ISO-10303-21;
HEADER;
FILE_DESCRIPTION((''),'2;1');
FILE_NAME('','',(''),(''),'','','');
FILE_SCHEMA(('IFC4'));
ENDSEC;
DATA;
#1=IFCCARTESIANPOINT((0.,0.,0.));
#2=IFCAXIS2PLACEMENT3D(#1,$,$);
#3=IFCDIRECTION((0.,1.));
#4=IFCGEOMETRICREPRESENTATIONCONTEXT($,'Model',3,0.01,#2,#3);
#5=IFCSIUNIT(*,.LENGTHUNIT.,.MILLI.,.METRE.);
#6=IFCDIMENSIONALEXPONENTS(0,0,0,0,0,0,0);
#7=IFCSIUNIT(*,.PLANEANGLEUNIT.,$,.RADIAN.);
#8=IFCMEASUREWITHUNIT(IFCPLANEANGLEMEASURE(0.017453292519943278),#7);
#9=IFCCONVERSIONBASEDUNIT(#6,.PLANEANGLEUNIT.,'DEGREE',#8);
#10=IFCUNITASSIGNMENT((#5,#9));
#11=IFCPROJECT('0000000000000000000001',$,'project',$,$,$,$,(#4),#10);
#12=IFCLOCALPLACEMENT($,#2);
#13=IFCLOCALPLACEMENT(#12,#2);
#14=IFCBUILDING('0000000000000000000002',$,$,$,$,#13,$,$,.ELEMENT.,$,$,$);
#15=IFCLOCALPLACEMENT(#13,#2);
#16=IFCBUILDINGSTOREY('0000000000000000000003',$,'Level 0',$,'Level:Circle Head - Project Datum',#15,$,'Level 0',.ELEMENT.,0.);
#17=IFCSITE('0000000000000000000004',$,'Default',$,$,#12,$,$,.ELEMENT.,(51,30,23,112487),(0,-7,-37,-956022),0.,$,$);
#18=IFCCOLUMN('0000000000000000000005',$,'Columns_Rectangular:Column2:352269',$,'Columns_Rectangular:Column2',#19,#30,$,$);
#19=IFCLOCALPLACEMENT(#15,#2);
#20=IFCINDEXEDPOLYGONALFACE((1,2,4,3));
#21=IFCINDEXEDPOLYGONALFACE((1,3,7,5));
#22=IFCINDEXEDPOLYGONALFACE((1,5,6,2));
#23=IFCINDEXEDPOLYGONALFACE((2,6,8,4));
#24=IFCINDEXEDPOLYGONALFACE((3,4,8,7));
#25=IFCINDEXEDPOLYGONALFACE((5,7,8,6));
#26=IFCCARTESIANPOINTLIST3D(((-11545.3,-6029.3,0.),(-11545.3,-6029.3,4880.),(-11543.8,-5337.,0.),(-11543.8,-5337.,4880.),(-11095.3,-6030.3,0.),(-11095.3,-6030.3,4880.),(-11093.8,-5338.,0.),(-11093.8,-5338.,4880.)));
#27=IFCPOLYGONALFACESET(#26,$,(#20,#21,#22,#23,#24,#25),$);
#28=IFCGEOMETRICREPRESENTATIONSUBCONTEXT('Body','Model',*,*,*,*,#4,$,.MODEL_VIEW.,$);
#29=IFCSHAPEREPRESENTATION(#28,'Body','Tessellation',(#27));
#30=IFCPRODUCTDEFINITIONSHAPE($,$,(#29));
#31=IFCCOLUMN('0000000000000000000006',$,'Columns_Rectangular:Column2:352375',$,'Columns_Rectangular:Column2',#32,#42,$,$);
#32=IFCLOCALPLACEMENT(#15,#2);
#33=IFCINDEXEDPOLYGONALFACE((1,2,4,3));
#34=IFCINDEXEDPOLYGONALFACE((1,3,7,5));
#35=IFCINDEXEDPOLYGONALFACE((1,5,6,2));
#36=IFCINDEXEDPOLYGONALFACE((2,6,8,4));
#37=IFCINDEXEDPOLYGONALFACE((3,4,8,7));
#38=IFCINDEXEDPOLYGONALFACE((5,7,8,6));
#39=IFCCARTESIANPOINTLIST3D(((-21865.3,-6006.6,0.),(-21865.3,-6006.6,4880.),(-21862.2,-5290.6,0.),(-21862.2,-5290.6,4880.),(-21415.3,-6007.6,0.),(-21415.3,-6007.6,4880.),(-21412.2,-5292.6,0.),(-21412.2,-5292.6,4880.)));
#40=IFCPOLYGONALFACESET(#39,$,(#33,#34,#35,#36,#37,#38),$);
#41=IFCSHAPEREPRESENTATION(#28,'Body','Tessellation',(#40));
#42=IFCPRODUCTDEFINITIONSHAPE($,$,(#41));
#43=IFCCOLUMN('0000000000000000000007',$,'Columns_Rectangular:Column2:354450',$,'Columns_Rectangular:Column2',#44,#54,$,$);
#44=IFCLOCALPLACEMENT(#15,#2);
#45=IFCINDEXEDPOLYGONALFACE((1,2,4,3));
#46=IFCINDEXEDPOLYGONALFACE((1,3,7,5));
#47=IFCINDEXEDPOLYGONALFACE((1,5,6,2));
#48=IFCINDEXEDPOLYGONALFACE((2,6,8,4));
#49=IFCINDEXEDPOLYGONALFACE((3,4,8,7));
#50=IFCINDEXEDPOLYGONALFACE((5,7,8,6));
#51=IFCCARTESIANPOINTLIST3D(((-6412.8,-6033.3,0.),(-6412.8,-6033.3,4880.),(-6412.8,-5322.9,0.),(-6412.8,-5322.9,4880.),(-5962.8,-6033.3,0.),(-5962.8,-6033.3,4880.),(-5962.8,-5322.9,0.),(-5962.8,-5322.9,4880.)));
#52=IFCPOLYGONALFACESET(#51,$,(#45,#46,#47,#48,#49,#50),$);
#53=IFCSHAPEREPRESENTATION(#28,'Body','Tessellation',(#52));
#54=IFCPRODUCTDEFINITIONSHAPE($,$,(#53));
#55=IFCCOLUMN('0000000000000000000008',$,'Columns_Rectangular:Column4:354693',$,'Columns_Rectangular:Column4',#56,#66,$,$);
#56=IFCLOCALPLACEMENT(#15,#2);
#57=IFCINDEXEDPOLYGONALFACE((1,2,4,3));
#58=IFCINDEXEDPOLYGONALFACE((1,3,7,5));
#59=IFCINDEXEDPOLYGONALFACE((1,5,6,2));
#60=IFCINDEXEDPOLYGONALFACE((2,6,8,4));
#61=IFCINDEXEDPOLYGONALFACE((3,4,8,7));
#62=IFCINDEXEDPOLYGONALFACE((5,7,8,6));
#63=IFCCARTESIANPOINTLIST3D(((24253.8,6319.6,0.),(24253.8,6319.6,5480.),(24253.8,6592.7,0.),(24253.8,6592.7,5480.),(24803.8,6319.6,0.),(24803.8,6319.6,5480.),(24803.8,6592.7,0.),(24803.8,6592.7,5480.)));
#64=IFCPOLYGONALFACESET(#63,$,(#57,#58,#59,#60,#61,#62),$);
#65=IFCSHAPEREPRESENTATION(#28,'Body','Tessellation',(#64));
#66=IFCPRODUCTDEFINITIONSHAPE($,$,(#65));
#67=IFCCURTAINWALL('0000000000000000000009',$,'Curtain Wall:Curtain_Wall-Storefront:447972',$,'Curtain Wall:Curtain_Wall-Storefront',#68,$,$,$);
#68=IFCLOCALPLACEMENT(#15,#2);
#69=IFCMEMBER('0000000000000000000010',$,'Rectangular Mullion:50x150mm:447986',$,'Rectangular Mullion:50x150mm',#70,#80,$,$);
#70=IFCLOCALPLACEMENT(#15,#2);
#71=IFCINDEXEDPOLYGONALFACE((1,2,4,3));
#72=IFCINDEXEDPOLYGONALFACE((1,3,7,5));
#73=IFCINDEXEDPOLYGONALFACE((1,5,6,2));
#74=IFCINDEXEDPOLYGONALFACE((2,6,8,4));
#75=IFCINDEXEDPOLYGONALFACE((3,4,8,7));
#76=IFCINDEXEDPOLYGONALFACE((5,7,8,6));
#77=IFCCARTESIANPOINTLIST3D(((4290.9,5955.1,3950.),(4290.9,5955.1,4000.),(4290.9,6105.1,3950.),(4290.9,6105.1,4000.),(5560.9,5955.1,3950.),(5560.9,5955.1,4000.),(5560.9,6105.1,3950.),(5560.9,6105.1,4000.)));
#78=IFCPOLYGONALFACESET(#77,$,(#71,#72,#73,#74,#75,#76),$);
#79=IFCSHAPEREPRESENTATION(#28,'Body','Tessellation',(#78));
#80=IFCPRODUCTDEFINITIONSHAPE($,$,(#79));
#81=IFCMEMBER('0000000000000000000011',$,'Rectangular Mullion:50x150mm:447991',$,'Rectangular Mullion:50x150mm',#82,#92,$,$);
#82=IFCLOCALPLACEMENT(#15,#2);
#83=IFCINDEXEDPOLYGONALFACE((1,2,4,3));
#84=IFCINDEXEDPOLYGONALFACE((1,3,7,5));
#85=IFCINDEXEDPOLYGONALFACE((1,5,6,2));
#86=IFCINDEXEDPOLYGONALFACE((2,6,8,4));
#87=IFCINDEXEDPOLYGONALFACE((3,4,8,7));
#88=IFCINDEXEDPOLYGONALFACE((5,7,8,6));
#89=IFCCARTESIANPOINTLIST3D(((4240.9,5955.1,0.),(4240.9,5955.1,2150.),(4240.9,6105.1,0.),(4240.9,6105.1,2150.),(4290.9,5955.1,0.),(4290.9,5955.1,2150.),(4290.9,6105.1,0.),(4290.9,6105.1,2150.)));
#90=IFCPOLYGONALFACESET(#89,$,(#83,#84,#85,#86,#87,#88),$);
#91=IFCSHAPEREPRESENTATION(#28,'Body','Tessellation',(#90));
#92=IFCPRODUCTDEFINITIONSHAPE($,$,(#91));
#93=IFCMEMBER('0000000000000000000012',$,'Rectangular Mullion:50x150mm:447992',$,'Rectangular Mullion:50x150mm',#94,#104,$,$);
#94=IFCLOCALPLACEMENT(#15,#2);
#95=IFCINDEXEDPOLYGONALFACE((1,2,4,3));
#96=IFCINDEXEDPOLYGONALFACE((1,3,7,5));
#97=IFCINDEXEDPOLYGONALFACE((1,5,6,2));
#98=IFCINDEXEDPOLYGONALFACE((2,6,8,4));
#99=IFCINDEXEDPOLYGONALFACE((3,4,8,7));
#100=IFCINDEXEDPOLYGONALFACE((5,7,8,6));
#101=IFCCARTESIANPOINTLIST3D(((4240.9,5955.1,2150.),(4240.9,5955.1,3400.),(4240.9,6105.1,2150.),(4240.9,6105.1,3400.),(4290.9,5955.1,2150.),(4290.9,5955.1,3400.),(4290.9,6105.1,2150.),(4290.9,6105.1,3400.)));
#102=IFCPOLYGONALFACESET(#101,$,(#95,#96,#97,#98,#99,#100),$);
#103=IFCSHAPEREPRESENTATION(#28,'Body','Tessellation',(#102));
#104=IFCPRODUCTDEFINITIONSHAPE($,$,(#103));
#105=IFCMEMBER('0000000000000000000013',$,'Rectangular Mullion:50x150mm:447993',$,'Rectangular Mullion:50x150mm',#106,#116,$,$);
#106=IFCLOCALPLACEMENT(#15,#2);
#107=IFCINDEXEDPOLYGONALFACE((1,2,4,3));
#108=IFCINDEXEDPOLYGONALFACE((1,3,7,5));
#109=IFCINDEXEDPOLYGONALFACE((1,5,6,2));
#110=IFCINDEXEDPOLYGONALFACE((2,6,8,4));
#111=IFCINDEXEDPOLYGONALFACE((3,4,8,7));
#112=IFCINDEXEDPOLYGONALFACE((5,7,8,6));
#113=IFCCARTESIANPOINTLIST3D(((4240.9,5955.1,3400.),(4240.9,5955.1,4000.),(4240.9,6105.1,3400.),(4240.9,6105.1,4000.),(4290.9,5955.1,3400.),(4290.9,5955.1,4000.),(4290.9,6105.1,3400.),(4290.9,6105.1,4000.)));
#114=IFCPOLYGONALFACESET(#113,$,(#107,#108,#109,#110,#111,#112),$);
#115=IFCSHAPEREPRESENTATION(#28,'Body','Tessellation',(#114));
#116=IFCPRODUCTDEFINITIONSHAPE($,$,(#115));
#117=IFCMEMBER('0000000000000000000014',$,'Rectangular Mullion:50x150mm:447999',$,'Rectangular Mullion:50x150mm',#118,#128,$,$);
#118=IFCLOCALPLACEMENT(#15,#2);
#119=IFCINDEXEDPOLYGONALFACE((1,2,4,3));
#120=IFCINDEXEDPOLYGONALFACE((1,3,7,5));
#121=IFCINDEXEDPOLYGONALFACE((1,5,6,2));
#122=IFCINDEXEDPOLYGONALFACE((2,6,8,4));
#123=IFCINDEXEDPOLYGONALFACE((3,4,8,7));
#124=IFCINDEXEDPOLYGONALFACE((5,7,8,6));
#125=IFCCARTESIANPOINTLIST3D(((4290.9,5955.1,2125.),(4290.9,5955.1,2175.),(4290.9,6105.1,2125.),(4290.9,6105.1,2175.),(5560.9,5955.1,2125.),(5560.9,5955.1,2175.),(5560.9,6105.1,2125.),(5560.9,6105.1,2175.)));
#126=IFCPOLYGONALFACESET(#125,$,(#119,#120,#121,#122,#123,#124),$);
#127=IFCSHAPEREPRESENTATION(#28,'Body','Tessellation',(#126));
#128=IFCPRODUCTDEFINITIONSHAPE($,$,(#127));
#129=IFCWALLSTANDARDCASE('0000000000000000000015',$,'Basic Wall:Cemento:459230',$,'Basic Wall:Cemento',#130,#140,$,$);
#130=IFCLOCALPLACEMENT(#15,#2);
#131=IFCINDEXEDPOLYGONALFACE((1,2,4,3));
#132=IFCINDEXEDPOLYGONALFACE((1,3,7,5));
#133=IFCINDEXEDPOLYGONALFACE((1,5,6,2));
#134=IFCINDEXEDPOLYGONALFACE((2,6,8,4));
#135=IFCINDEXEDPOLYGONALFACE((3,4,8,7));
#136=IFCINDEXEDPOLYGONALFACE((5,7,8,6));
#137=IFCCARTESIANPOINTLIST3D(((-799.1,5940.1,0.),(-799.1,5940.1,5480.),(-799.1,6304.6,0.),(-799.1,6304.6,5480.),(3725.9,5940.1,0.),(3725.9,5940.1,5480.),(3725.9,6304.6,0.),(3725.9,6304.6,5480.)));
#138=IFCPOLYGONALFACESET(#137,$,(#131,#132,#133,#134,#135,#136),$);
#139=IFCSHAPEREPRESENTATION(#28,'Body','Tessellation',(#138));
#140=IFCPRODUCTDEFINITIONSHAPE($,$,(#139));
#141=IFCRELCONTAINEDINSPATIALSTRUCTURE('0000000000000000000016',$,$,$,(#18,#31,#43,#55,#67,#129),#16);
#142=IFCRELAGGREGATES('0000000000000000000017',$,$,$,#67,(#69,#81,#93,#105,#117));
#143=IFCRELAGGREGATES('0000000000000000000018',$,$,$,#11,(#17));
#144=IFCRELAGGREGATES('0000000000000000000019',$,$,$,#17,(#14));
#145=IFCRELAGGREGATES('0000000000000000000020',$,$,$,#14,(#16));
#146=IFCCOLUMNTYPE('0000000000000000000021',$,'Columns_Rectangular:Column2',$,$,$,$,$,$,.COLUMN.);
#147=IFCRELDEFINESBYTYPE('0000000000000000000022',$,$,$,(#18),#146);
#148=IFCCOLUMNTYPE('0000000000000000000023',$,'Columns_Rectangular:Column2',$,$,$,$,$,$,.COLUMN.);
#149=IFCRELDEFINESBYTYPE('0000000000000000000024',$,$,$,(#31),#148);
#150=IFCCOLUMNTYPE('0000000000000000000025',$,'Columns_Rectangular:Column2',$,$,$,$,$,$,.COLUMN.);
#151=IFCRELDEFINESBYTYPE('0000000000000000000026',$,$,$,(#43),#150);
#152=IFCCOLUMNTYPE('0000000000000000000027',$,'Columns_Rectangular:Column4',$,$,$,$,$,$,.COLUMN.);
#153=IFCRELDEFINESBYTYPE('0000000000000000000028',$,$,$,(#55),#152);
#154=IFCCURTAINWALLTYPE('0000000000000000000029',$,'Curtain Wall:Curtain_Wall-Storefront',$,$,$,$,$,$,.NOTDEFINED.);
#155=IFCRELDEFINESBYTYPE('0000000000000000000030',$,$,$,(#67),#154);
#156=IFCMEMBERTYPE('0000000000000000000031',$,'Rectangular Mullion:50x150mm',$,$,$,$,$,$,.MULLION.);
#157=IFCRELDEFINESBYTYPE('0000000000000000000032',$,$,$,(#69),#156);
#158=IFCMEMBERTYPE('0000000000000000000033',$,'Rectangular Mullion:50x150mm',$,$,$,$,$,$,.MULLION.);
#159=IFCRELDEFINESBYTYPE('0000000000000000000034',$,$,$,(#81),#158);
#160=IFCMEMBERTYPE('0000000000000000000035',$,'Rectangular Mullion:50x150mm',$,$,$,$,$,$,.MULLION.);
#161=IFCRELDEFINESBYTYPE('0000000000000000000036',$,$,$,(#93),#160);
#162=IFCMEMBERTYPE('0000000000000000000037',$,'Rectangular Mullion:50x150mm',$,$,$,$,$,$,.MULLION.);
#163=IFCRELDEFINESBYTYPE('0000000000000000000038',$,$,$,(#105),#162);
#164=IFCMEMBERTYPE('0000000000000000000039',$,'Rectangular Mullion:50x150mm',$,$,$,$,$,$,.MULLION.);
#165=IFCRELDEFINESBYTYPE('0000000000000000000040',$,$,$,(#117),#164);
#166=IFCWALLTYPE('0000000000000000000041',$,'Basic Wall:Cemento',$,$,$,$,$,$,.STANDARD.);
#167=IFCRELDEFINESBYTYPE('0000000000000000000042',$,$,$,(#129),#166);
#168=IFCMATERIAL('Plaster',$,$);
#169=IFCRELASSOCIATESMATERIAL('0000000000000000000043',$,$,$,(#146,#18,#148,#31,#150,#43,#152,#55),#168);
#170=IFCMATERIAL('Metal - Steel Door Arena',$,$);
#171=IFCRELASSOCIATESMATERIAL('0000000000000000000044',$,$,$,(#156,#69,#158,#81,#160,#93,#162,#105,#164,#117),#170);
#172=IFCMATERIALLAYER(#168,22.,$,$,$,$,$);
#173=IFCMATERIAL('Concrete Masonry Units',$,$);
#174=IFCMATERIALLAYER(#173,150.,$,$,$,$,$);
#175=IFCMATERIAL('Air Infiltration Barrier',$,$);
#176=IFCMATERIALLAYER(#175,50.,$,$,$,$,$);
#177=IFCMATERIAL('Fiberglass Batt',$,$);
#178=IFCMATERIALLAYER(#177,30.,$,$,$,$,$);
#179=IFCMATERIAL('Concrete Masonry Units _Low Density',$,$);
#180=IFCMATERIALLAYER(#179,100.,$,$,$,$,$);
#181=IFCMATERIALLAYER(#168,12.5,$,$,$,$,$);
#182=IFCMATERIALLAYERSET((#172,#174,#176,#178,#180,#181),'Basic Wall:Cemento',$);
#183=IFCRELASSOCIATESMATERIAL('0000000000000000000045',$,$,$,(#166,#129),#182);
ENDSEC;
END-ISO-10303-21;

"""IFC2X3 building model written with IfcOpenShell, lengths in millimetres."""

from ifc_helpers import new_model, entity, si_unit, converted_unit, direction, frame, frame_2d, origin, origin_2d_with_axis, place, context, subcontext, project, spatial, polyline, rectangle, outline, extrude, source, transform, mapped, material, layer, layer_set, layer_usage, type_object, type_shapes, element, aggregate, save


model = new_model("IFC2X3")

# Units and contexts
model_context = context("Model", 3, precision=0.01, world=origin(), true_north=direction((0.0, 1.0)))
body_context = subcontext(model_context, "Body", "Model", "MODEL_VIEW")
ifc_project = project(units=[si_unit("LENGTHUNIT", "METRE", prefix="MILLI"), converted_unit("PLANEANGLEUNIT", "DEGREE", entity("IfcPlaneAngleMeasure", 0.017453292519943278), si_unit("PLANEANGLEUNIT", "RADIAN"), dimensions=[0, 0, 0, 0, 0, 0, 0])], contexts=[model_context])

# Site, building, storey
site_placement = place(None, origin())
site = spatial("IfcSite", under=ifc_project, at=site_placement, Name="Default", CompositionType="ELEMENT", RefLatitude=(51, 30, 23, 112487), RefLongitude=(0, -7, -37, -956022), RefElevation=0.0)
building_placement = place(site_placement, origin())
building = spatial("IfcBuilding", under=site, at=building_placement, CompositionType="ELEMENT")
storey_placement = place(building_placement, origin())
storey = spatial("IfcBuildingStorey", under=building, at=storey_placement, Name="Level 0", ObjectType="Level:Circle Head - Project Datum", LongName="Level 0", CompositionType="ELEMENT", Elevation=0.0)

# Columns
ifc_material_1 = material(Name="Plaster")
column_type_1 = type_object("IfcColumnType", Name="Columns_Rectangular:Column2", PredefinedType="COLUMN", material=ifc_material_1)
shared_shape_1 = source(origin(), body_context, "Body", "SweptSolid", [
    extrude(outline(polyline([(-346.1, -225.0), (346.1, -225.0), (346.1, 225.0), (-346.1, 225.0), (-346.1, -225.0)])), frame((-11319.5, -5683.6, 0.0), z_axis=(0.0, 0.0, 1.0), x_axis=(-0.002173, -0.999998, 0.0)), (0.0, 0.0, 1.0), 4880.0),
])
type_shapes(column_type_1, [shared_shape_1])
column_1_placement = place(storey_placement, origin())
element("IfcColumn", 1, at=column_1_placement, inside=storey, type_object=column_type_1, material=ifc_material_1, Name="Columns_Rectangular:Column2:352269", ObjectType="Columns_Rectangular:Column2", context=body_context, shape_type="MappedRepresentation", body=[
    mapped(shared_shape_1, transform((0.0, 0.0, 0.0), scale=1.0)),
])
column_type_2 = type_object("IfcColumnType", Name="Columns_Rectangular:Column2", PredefinedType="COLUMN", material=ifc_material_1)
shared_shape_2 = source(origin(), body_context, "Body", "SweptSolid", [
    extrude(outline(polyline([(-357.8, -225.0), (358.3, -225.0), (357.3, 225.0), (-357.8, 225.0), (-357.8, -225.0)])), frame((-21638.7, -5649.3, 0.0), z_axis=(0.0, 0.0, 1.0), x_axis=(-0.004372, -0.99999, 0.0)), (0.0, 0.0, 1.0), 4880.0),
])
type_shapes(column_type_2, [shared_shape_2])
column_2_placement = place(storey_placement, origin())
element("IfcColumn", 2, at=column_2_placement, inside=storey, type_object=column_type_2, material=ifc_material_1, Name="Columns_Rectangular:Column2:352375", ObjectType="Columns_Rectangular:Column2", context=body_context, shape_type="MappedRepresentation", body=[
    mapped(shared_shape_2, transform((0.0, 0.0, 0.0), scale=1.0)),
])
column_type_3 = type_object("IfcColumnType", Name="Columns_Rectangular:Column2", PredefinedType="COLUMN", material=ifc_material_1)
shared_shape_3 = source(origin(), body_context, "Body", "SweptSolid", [
    extrude(rectangle(XDim=710.3, YDim=450.0, at=frame_2d((0.0, 0.0), x_axis=(1.0, 0.0))), frame((-6187.8, -5678.1, 0.0), z_axis=(0.0, 0.0, 1.0), x_axis=(0.0, -1.0, 0.0)), (0.0, 0.0, 1.0), 4880.0),
])
type_shapes(column_type_3, [shared_shape_3])
column_3_placement = place(storey_placement, origin())
element("IfcColumn", 3, at=column_3_placement, inside=storey, type_object=column_type_3, material=ifc_material_1, Name="Columns_Rectangular:Column2:354450", ObjectType="Columns_Rectangular:Column2", context=body_context, shape_type="MappedRepresentation", body=[
    mapped(shared_shape_3, transform((0.0, 0.0, 0.0), scale=1.0)),
])
column_type_4 = type_object("IfcColumnType", Name="Columns_Rectangular:Column4", PredefinedType="COLUMN", material=ifc_material_1)
shared_shape_4 = source(origin(), body_context, "Body", "SweptSolid", [
    extrude(rectangle(XDim=273.1, YDim=550.0, at=frame_2d((0.0, 0.0), x_axis=(1.0, 0.0))), frame((24528.8, 6456.2, 0.0), z_axis=(0.0, 0.0, 1.0), x_axis=(0.0, -1.0, 0.0)), (0.0, 0.0, 1.0), 5480.0),
])
type_shapes(column_type_4, [shared_shape_4])
column_4_placement = place(storey_placement, origin())
element("IfcColumn", 4, at=column_4_placement, inside=storey, type_object=column_type_4, material=ifc_material_1, Name="Columns_Rectangular:Column4:354693", ObjectType="Columns_Rectangular:Column4", context=body_context, shape_type="MappedRepresentation", body=[
    mapped(shared_shape_4, transform((0.0, 0.0, 0.0), scale=1.0)),
])

# Curtain wall, members
curtain_wall_type = type_object("IfcCurtainWallType", Name="Curtain Wall:Curtain_Wall-Storefront", PredefinedType="NOTDEFINED")
curtain_wall_placement = place(storey_placement, origin())
curtain_wall = element("IfcCurtainWall", 5, at=curtain_wall_placement, inside=storey, type_object=curtain_wall_type, Name="Curtain Wall:Curtain_Wall-Storefront:447972", ObjectType="Curtain Wall:Curtain_Wall-Storefront")
ifc_material_2 = material(Name="Metal - Steel Door Arena")
member_type_1 = type_object("IfcMemberType", Name="Rectangular Mullion:50x150mm", PredefinedType="MULLION", material=ifc_material_2)
shared_shape_5 = source(origin(), body_context, "Body", "SweptSolid", [
    extrude(rectangle(XDim=50.0, YDim=150.0, at=origin_2d_with_axis()), frame((-25.0, 0.0, -1270.0), z_axis=(0.0, 0.0, 1.0), x_axis=(-1.0, 0.0, 0.0)), (0.0, 0.0, 1.0), 1270.0),
])
type_shapes(member_type_1, [shared_shape_5])
member_1_placement = place(curtain_wall_placement, frame((4290.9, 6030.1, 4000.0), z_axis=(-1.0, 0.0, 0.0), x_axis=(0.0, 0.0, 1.0)))
member_1 = element("IfcMember", 6, at=member_1_placement, type_object=member_type_1, material=ifc_material_2, Name="Rectangular Mullion:50x150mm:447986", ObjectType="Rectangular Mullion:50x150mm", context=body_context, shape_type="MappedRepresentation", body=[
    mapped(shared_shape_5, transform((0.0, 0.0, 0.0), scale=1.0)),
])
member_type_2 = type_object("IfcMemberType", Name="Rectangular Mullion:50x150mm", PredefinedType="MULLION", material=ifc_material_2)
shared_shape_6 = source(origin(), body_context, "Body", "SweptSolid", [
    extrude(rectangle(XDim=50.0, YDim=150.0, at=origin_2d_with_axis()), frame((-25.0, 0.0, -2150.0), z_axis=(0.0, 0.0, 1.0), x_axis=(-1.0, 0.0, 0.0)), (0.0, 0.0, 1.0), 2150.0),
])
type_shapes(member_type_2, [shared_shape_6])
member_2_placement = place(curtain_wall_placement, frame((4240.9, 6030.1, 0.0), z_axis=(0.0, 0.0, -1.0), x_axis=(-1.0, 0.0, 0.0)))
member_2 = element("IfcMember", 7, at=member_2_placement, type_object=member_type_2, material=ifc_material_2, Name="Rectangular Mullion:50x150mm:447991", ObjectType="Rectangular Mullion:50x150mm", context=body_context, shape_type="MappedRepresentation", body=[
    mapped(shared_shape_6, transform((0.0, 0.0, 0.0), scale=1.0)),
])
member_type_3 = type_object("IfcMemberType", Name="Rectangular Mullion:50x150mm", PredefinedType="MULLION", material=ifc_material_2)
shared_shape_7 = source(origin(), body_context, "Body", "SweptSolid", [
    extrude(rectangle(XDim=50.0, YDim=150.0, at=origin_2d_with_axis()), frame((-25.0, 0.0, -1250.0), z_axis=(0.0, 0.0, 1.0), x_axis=(-1.0, 0.0, 0.0)), (0.0, 0.0, 1.0), 1250.0),
])
type_shapes(member_type_3, [shared_shape_7])
member_3_placement = place(curtain_wall_placement, frame((4240.9, 6030.1, 2150.0), z_axis=(0.0, 0.0, -1.0), x_axis=(-1.0, 0.0, 0.0)))
member_3 = element("IfcMember", 8, at=member_3_placement, type_object=member_type_3, material=ifc_material_2, Name="Rectangular Mullion:50x150mm:447992", ObjectType="Rectangular Mullion:50x150mm", context=body_context, shape_type="MappedRepresentation", body=[
    mapped(shared_shape_7, transform((0.0, 0.0, 0.0), scale=1.0)),
])
member_type_4 = type_object("IfcMemberType", Name="Rectangular Mullion:50x150mm", PredefinedType="MULLION", material=ifc_material_2)
shared_shape_8 = source(origin(), body_context, "Body", "SweptSolid", [
    extrude(rectangle(XDim=50.0, YDim=150.0, at=origin_2d_with_axis()), frame((-25.0, 0.0, -600.0), z_axis=(0.0, 0.0, 1.0), x_axis=(-1.0, 0.0, 0.0)), (0.0, 0.0, 1.0), 600.0),
])
type_shapes(member_type_4, [shared_shape_8])
member_4_placement = place(curtain_wall_placement, frame((4240.9, 6030.1, 3400.0), z_axis=(0.0, 0.0, -1.0), x_axis=(-1.0, 0.0, 0.0)))
member_4 = element("IfcMember", 9, at=member_4_placement, type_object=member_type_4, material=ifc_material_2, Name="Rectangular Mullion:50x150mm:447993", ObjectType="Rectangular Mullion:50x150mm", context=body_context, shape_type="MappedRepresentation", body=[
    mapped(shared_shape_8, transform((0.0, 0.0, 0.0), scale=1.0)),
])
member_type_5 = type_object("IfcMemberType", Name="Rectangular Mullion:50x150mm", PredefinedType="MULLION", material=ifc_material_2)
shared_shape_9 = source(origin(), body_context, "Body", "SweptSolid", [
    extrude(rectangle(XDim=50.0, YDim=150.0, at=origin_2d_with_axis()), frame((0.0, 0.0, -1270.0), z_axis=(0.0, 0.0, 1.0), x_axis=(-1.0, 0.0, 0.0)), (0.0, 0.0, 1.0), 1270.0),
])
type_shapes(member_type_5, [shared_shape_9])
member_5_placement = place(curtain_wall_placement, frame((4290.9, 6030.1, 2150.0), z_axis=(-1.0, 0.0, 0.0), x_axis=(0.0, 0.0, 1.0)))
member_5 = element("IfcMember", 10, at=member_5_placement, type_object=member_type_5, material=ifc_material_2, Name="Rectangular Mullion:50x150mm:447999", ObjectType="Rectangular Mullion:50x150mm", context=body_context, shape_type="MappedRepresentation", body=[
    mapped(shared_shape_9, transform((0.0, 0.0, 0.0), scale=1.0)),
])
aggregate(curtain_wall, [member_1, member_2, member_3, member_4, member_5])

# Wall
ifc_layer_1 = layer(ifc_material_1, 22.0)
ifc_material_3 = material(Name="Concrete Masonry Units")
ifc_layer_2 = layer(ifc_material_3, 150.0)
ifc_material_4 = material(Name="Air Infiltration Barrier")
ifc_layer_3 = layer(ifc_material_4, 50.0)
ifc_material_5 = material(Name="Fiberglass Batt")
ifc_layer_4 = layer(ifc_material_5, 30.0)
ifc_material_6 = material(Name="Concrete Masonry Units _Low Density")
ifc_layer_5 = layer(ifc_material_6, 100.0)
ifc_layer_6 = layer(ifc_material_1, 12.5)
ifc_layer_set = layer_set([ifc_layer_1, ifc_layer_2, ifc_layer_3, ifc_layer_4, ifc_layer_5, ifc_layer_6], Name="Basic Wall:Cemento")
ifc_layer_usage = layer_usage(ifc_layer_set, "AXIS2", "NEGATIVE", 182.3)
wall_type = type_object("IfcWallType", Name="Basic Wall:Cemento", PredefinedType="STANDARD", material=ifc_layer_set)
wall_placement = place(storey_placement, frame((3725.9, 6122.4, 0.0), z_axis=(0.0, 0.0, 1.0), x_axis=(-1.0, 0.0, 0.0)))
element("IfcWallStandardCase", 11, at=wall_placement, inside=storey, type_object=wall_type, material=ifc_layer_usage, Name="Basic Wall:Cemento:459230", ObjectType="Basic Wall:Cemento", context=body_context, shape_type="SweptSolid", body=[
    extrude(rectangle(XDim=4525.0, YDim=364.5, at=frame_2d((2262.5, 0.0), x_axis=(-1.0, 0.0))), origin(), (0.0, 0.0, 1.0), 5480.0),
])

save(model, "model.ifc")
